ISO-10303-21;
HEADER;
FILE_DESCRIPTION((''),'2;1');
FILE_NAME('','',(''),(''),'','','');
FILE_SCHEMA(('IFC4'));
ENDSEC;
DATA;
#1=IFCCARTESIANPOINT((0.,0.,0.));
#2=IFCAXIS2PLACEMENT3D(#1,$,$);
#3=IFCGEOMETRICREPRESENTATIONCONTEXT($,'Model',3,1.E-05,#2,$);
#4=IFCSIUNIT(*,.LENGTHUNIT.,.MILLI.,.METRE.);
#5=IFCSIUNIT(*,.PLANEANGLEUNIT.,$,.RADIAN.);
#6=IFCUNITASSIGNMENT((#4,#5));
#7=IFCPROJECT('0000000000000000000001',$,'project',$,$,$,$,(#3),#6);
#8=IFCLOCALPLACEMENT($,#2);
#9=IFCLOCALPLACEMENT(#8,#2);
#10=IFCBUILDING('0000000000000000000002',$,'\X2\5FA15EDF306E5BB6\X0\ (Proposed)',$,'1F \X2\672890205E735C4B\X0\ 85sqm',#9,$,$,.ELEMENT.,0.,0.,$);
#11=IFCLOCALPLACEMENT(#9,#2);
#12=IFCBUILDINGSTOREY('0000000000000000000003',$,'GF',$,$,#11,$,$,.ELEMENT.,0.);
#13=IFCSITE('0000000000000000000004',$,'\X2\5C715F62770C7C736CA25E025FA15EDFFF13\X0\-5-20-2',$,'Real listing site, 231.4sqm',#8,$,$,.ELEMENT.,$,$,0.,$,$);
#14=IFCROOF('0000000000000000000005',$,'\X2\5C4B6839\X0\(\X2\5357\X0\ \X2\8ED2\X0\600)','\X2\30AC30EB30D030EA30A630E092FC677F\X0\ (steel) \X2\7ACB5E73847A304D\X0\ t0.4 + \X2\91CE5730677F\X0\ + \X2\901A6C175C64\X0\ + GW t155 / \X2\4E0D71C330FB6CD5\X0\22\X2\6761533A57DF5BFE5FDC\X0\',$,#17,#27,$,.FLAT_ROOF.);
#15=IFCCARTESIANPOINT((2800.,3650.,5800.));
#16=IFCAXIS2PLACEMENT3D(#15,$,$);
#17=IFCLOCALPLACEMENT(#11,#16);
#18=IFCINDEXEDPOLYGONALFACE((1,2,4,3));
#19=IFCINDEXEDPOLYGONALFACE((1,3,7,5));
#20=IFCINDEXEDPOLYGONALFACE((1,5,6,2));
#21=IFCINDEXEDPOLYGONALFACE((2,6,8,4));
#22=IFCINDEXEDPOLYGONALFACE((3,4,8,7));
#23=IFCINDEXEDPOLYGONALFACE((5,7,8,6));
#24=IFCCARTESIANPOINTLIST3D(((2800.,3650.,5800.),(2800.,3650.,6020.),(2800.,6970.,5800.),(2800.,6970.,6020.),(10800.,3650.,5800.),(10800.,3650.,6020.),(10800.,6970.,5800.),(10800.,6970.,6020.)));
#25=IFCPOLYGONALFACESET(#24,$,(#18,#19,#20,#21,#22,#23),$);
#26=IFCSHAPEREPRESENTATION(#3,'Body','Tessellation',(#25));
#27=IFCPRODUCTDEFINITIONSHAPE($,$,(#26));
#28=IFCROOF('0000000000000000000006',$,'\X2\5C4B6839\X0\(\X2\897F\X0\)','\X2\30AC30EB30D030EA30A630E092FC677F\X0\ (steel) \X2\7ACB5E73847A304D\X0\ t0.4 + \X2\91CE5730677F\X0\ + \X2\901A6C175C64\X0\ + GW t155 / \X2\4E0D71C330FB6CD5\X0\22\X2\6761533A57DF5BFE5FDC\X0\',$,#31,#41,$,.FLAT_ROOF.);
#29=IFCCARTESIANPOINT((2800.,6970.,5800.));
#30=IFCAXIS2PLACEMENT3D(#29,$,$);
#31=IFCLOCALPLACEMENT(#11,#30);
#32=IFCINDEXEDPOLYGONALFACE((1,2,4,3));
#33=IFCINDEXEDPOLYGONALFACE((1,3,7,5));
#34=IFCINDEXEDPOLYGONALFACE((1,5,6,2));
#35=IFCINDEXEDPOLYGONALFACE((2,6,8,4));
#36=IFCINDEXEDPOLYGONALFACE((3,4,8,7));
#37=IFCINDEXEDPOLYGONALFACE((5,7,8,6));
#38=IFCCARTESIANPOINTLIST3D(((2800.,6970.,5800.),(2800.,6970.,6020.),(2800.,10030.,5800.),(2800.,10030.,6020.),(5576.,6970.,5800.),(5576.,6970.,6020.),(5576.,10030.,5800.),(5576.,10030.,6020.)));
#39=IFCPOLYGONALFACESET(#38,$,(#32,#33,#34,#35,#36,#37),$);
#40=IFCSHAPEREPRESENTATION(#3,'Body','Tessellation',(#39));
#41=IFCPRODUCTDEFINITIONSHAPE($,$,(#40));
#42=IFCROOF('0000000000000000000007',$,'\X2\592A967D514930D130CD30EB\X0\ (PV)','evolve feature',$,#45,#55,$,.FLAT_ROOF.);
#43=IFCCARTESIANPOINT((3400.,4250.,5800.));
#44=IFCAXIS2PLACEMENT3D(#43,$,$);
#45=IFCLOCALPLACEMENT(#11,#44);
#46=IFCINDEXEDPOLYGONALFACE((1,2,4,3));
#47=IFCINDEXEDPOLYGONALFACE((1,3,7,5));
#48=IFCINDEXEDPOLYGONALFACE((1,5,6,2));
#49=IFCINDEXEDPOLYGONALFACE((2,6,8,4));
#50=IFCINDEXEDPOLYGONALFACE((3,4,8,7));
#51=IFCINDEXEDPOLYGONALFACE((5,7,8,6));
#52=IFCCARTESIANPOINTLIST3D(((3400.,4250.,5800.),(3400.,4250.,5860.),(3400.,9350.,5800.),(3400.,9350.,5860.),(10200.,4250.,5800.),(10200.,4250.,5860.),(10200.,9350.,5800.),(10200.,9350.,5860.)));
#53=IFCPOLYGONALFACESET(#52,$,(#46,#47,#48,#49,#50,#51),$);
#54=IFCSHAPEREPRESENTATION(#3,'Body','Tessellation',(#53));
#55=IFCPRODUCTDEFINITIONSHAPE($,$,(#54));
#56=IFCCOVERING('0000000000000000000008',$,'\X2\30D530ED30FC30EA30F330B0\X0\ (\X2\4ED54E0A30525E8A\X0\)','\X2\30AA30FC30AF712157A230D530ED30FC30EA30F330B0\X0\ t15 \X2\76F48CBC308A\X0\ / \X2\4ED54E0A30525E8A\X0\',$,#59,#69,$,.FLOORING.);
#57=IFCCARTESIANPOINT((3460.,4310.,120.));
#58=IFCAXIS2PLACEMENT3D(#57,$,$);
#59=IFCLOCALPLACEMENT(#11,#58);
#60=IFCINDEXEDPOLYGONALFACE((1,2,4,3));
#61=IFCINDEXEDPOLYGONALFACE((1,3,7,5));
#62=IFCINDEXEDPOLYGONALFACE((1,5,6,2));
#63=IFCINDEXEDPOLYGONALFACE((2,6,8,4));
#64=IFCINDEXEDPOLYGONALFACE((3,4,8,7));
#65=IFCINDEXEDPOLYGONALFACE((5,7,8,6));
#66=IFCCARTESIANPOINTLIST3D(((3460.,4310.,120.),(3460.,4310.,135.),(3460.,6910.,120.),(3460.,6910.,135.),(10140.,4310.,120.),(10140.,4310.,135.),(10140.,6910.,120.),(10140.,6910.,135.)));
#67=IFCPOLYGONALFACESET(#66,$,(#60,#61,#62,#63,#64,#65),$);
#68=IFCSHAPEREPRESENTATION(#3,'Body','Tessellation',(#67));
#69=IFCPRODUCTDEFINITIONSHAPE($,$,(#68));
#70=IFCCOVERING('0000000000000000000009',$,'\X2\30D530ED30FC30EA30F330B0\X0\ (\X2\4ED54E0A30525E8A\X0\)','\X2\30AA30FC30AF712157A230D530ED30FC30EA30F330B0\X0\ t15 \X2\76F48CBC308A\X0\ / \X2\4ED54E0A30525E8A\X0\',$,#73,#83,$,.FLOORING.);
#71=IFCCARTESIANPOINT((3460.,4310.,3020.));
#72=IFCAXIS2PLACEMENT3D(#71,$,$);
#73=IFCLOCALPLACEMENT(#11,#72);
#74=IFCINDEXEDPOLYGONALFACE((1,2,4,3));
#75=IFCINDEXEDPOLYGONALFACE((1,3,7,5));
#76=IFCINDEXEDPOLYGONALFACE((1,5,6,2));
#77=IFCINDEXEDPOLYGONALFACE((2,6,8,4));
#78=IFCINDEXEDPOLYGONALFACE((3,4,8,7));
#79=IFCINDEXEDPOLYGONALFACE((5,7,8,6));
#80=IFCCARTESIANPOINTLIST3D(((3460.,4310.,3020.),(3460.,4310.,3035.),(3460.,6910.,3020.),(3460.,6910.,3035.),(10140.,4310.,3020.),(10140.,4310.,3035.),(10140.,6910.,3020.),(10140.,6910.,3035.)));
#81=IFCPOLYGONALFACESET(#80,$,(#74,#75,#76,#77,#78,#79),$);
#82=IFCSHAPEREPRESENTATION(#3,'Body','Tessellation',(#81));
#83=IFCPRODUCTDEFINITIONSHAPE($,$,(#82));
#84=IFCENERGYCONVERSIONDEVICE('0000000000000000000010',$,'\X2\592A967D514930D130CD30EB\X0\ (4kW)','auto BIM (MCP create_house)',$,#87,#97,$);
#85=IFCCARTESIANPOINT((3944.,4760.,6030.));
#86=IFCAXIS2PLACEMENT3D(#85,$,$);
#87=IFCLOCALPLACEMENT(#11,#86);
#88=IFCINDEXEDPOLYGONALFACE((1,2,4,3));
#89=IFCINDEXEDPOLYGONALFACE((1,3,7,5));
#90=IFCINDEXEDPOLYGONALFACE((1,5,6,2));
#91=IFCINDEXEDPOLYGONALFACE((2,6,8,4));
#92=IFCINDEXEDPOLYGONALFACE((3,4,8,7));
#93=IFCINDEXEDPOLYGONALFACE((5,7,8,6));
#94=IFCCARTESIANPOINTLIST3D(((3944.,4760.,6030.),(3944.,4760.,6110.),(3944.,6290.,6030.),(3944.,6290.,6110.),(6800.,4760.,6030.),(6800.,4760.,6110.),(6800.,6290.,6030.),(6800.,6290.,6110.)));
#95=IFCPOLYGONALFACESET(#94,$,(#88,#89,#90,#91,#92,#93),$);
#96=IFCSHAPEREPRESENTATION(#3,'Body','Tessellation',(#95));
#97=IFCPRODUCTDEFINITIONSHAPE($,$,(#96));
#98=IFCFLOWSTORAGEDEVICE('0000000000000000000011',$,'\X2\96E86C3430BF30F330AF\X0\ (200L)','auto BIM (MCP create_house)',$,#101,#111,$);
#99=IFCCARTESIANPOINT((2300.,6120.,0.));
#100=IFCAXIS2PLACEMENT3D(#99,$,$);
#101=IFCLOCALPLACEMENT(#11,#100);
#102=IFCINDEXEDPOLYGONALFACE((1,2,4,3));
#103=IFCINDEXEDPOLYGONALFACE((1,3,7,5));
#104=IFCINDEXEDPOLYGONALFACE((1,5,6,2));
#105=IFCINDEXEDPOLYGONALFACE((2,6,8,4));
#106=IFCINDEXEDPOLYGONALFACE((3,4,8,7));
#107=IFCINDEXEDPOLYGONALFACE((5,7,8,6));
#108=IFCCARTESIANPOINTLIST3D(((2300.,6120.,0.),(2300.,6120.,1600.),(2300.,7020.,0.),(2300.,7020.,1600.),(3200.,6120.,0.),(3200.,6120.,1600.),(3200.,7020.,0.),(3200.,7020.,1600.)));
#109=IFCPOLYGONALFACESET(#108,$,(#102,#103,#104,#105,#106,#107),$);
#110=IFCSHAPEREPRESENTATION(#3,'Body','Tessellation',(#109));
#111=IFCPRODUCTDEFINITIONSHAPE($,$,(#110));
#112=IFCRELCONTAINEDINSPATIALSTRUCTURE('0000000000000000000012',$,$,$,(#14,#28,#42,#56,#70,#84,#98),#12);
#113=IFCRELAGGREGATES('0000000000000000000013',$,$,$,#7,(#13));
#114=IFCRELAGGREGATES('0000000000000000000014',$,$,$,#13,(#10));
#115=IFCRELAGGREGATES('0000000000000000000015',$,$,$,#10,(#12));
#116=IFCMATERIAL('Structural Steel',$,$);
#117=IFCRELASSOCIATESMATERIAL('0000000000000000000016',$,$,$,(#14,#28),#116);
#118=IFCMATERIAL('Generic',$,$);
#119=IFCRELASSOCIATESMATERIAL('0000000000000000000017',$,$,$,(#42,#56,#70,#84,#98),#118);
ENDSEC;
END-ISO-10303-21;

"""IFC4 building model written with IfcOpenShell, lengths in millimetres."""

from ifc_helpers import new_model, si_unit, frame, frame_2d, origin, place, context, project, spatial, rectangle, extrude, material, element, save


model = new_model("IFC4")

# Units and contexts
model_context = context("Model", 3, precision=1e-05, world=origin())
ifc_project = project(units=[si_unit("LENGTHUNIT", "METRE", prefix="MILLI"), si_unit("PLANEANGLEUNIT", "RADIAN")], contexts=[model_context])

# Site, building, storey
site_placement = place(None, origin())
site = spatial("IfcSite", under=ifc_project, at=site_placement, Name="山形県米沢市御廟３-5-20-2", ObjectType="Real listing site, 231.4sqm", CompositionType="ELEMENT", RefElevation=0.0)
building_placement = place(site_placement, origin())
building = spatial("IfcBuilding", under=site, at=building_placement, Name="御廟の家 (Proposed)", ObjectType="1F 木造平屋 85sqm", CompositionType="ELEMENT", ElevationOfRefHeight=0.0, ElevationOfTerrain=0.0)
storey_placement = place(building_placement, origin())
storey = spatial("IfcBuildingStorey", under=building, at=storey_placement, Name="GF", CompositionType="ELEMENT", Elevation=0.0)

# Shared definitions
ifc_material_1 = material(Name="Generic")

# Roofs
ifc_material_2 = material(Name="Structural Steel")
roof_1_placement = place(storey_placement, frame((2800.0, 3650.0, 5800.0)))
element("IfcRoof", 1, at=roof_1_placement, inside=storey, material=ifc_material_2, Name="屋根(南 軒600)", Description="ガルバリウム鋼板 (steel) 立平葺き t0.4 + 野地板 + 通気層 + GW t155 / 不燃・法22条区域対応", PredefinedType="FLAT_ROOF", context=model_context, shape_type="SweptSolid", body=[
    extrude(rectangle(XDim=8000.0, YDim=3320.0, at=frame_2d((4000.0, 1660.0))), frame((2800.0, 3650.0, 5800.0)), (0.0, 0.0, 1.0), 220.0),
])
roof_2_placement = place(storey_placement, frame((2800.0, 6970.0, 5800.0)))
element("IfcRoof", 2, at=roof_2_placement, inside=storey, material=ifc_material_2, Name="屋根(西)", Description="ガルバリウム鋼板 (steel) 立平葺き t0.4 + 野地板 + 通気層 + GW t155 / 不燃・法22条区域対応", PredefinedType="FLAT_ROOF", context=model_context, shape_type="SweptSolid", body=[
    extrude(rectangle(XDim=2776.0, YDim=3060.0, at=frame_2d((1388.0, 1530.0))), frame((2800.0, 6970.0, 5800.0)), (0.0, 0.0, 1.0), 220.0),
])
roof_3_placement = place(storey_placement, frame((3400.0, 4250.0, 5800.0)))
element("IfcRoof", 3, at=roof_3_placement, inside=storey, material=ifc_material_1, Name="太陽光パネル (PV)", Description="evolve feature", PredefinedType="FLAT_ROOF", context=model_context, shape_type="SweptSolid", body=[
    extrude(rectangle(XDim=6800.0, YDim=5100.0, at=frame_2d((3400.0, 2550.0))), frame((3400.0, 4250.0, 5800.0)), (0.0, 0.0, 1.0), 60.0),
])

# Coverings
covering_1_placement = place(storey_placement, frame((3460.0, 4310.0, 120.0)))
element("IfcCovering", 4, at=covering_1_placement, inside=storey, material=ifc_material_1, Name="フローリング (仕上げ床)", Description="オーク無垢フローリング t15 直貼り / 仕上げ床", PredefinedType="FLOORING", context=model_context, shape_type="SweptSolid", body=[
    extrude(rectangle(XDim=6680.0, YDim=2600.0, at=frame_2d((3340.0, 1300.0))), frame((3460.0, 4310.0, 120.0)), (0.0, 0.0, 1.0), 15.0),
])
covering_2_placement = place(storey_placement, frame((3460.0, 4310.0, 3020.0)))
element("IfcCovering", 5, at=covering_2_placement, inside=storey, material=ifc_material_1, Name="フローリング (仕上げ床)", Description="オーク無垢フローリング t15 直貼り / 仕上げ床", PredefinedType="FLOORING", context=model_context, shape_type="SweptSolid", body=[
    extrude(rectangle(XDim=6680.0, YDim=2600.0, at=frame_2d((3340.0, 1300.0))), frame((3460.0, 4310.0, 3020.0)), (0.0, 0.0, 1.0), 15.0),
])

# Energy conversion device
energy_conversion_device_placement = place(storey_placement, frame((3944.0, 4760.0, 6030.0)))
element("IfcEnergyConversionDevice", 6, at=energy_conversion_device_placement, inside=storey, material=ifc_material_1, Name="太陽光パネル (4kW)", Description="auto BIM (MCP create_house)", context=model_context, shape_type="SweptSolid", body=[
    extrude(rectangle(XDim=2856.0, YDim=1530.0, at=frame_2d((1428.0, 765.0))), frame((3944.0, 4760.0, 6030.0)), (0.0, 0.0, 1.0), 80.0),
])

# Flow storage device
flow_storage_device_placement = place(storey_placement, frame((2300.0, 6120.0, 0.0)))
element("IfcFlowStorageDevice", 7, at=flow_storage_device_placement, inside=storey, material=ifc_material_1, Name="雨水タンク (200L)", Description="auto BIM (MCP create_house)", context=model_context, shape_type="SweptSolid", body=[
    extrude(rectangle(XDim=900.0, YDim=900.0, at=frame_2d((450.0, 450.0))), frame((2300.0, 6120.0, 0.0)), (0.0, 0.0, 1.0), 1600.0),
])

save(model, "model.ifc")
